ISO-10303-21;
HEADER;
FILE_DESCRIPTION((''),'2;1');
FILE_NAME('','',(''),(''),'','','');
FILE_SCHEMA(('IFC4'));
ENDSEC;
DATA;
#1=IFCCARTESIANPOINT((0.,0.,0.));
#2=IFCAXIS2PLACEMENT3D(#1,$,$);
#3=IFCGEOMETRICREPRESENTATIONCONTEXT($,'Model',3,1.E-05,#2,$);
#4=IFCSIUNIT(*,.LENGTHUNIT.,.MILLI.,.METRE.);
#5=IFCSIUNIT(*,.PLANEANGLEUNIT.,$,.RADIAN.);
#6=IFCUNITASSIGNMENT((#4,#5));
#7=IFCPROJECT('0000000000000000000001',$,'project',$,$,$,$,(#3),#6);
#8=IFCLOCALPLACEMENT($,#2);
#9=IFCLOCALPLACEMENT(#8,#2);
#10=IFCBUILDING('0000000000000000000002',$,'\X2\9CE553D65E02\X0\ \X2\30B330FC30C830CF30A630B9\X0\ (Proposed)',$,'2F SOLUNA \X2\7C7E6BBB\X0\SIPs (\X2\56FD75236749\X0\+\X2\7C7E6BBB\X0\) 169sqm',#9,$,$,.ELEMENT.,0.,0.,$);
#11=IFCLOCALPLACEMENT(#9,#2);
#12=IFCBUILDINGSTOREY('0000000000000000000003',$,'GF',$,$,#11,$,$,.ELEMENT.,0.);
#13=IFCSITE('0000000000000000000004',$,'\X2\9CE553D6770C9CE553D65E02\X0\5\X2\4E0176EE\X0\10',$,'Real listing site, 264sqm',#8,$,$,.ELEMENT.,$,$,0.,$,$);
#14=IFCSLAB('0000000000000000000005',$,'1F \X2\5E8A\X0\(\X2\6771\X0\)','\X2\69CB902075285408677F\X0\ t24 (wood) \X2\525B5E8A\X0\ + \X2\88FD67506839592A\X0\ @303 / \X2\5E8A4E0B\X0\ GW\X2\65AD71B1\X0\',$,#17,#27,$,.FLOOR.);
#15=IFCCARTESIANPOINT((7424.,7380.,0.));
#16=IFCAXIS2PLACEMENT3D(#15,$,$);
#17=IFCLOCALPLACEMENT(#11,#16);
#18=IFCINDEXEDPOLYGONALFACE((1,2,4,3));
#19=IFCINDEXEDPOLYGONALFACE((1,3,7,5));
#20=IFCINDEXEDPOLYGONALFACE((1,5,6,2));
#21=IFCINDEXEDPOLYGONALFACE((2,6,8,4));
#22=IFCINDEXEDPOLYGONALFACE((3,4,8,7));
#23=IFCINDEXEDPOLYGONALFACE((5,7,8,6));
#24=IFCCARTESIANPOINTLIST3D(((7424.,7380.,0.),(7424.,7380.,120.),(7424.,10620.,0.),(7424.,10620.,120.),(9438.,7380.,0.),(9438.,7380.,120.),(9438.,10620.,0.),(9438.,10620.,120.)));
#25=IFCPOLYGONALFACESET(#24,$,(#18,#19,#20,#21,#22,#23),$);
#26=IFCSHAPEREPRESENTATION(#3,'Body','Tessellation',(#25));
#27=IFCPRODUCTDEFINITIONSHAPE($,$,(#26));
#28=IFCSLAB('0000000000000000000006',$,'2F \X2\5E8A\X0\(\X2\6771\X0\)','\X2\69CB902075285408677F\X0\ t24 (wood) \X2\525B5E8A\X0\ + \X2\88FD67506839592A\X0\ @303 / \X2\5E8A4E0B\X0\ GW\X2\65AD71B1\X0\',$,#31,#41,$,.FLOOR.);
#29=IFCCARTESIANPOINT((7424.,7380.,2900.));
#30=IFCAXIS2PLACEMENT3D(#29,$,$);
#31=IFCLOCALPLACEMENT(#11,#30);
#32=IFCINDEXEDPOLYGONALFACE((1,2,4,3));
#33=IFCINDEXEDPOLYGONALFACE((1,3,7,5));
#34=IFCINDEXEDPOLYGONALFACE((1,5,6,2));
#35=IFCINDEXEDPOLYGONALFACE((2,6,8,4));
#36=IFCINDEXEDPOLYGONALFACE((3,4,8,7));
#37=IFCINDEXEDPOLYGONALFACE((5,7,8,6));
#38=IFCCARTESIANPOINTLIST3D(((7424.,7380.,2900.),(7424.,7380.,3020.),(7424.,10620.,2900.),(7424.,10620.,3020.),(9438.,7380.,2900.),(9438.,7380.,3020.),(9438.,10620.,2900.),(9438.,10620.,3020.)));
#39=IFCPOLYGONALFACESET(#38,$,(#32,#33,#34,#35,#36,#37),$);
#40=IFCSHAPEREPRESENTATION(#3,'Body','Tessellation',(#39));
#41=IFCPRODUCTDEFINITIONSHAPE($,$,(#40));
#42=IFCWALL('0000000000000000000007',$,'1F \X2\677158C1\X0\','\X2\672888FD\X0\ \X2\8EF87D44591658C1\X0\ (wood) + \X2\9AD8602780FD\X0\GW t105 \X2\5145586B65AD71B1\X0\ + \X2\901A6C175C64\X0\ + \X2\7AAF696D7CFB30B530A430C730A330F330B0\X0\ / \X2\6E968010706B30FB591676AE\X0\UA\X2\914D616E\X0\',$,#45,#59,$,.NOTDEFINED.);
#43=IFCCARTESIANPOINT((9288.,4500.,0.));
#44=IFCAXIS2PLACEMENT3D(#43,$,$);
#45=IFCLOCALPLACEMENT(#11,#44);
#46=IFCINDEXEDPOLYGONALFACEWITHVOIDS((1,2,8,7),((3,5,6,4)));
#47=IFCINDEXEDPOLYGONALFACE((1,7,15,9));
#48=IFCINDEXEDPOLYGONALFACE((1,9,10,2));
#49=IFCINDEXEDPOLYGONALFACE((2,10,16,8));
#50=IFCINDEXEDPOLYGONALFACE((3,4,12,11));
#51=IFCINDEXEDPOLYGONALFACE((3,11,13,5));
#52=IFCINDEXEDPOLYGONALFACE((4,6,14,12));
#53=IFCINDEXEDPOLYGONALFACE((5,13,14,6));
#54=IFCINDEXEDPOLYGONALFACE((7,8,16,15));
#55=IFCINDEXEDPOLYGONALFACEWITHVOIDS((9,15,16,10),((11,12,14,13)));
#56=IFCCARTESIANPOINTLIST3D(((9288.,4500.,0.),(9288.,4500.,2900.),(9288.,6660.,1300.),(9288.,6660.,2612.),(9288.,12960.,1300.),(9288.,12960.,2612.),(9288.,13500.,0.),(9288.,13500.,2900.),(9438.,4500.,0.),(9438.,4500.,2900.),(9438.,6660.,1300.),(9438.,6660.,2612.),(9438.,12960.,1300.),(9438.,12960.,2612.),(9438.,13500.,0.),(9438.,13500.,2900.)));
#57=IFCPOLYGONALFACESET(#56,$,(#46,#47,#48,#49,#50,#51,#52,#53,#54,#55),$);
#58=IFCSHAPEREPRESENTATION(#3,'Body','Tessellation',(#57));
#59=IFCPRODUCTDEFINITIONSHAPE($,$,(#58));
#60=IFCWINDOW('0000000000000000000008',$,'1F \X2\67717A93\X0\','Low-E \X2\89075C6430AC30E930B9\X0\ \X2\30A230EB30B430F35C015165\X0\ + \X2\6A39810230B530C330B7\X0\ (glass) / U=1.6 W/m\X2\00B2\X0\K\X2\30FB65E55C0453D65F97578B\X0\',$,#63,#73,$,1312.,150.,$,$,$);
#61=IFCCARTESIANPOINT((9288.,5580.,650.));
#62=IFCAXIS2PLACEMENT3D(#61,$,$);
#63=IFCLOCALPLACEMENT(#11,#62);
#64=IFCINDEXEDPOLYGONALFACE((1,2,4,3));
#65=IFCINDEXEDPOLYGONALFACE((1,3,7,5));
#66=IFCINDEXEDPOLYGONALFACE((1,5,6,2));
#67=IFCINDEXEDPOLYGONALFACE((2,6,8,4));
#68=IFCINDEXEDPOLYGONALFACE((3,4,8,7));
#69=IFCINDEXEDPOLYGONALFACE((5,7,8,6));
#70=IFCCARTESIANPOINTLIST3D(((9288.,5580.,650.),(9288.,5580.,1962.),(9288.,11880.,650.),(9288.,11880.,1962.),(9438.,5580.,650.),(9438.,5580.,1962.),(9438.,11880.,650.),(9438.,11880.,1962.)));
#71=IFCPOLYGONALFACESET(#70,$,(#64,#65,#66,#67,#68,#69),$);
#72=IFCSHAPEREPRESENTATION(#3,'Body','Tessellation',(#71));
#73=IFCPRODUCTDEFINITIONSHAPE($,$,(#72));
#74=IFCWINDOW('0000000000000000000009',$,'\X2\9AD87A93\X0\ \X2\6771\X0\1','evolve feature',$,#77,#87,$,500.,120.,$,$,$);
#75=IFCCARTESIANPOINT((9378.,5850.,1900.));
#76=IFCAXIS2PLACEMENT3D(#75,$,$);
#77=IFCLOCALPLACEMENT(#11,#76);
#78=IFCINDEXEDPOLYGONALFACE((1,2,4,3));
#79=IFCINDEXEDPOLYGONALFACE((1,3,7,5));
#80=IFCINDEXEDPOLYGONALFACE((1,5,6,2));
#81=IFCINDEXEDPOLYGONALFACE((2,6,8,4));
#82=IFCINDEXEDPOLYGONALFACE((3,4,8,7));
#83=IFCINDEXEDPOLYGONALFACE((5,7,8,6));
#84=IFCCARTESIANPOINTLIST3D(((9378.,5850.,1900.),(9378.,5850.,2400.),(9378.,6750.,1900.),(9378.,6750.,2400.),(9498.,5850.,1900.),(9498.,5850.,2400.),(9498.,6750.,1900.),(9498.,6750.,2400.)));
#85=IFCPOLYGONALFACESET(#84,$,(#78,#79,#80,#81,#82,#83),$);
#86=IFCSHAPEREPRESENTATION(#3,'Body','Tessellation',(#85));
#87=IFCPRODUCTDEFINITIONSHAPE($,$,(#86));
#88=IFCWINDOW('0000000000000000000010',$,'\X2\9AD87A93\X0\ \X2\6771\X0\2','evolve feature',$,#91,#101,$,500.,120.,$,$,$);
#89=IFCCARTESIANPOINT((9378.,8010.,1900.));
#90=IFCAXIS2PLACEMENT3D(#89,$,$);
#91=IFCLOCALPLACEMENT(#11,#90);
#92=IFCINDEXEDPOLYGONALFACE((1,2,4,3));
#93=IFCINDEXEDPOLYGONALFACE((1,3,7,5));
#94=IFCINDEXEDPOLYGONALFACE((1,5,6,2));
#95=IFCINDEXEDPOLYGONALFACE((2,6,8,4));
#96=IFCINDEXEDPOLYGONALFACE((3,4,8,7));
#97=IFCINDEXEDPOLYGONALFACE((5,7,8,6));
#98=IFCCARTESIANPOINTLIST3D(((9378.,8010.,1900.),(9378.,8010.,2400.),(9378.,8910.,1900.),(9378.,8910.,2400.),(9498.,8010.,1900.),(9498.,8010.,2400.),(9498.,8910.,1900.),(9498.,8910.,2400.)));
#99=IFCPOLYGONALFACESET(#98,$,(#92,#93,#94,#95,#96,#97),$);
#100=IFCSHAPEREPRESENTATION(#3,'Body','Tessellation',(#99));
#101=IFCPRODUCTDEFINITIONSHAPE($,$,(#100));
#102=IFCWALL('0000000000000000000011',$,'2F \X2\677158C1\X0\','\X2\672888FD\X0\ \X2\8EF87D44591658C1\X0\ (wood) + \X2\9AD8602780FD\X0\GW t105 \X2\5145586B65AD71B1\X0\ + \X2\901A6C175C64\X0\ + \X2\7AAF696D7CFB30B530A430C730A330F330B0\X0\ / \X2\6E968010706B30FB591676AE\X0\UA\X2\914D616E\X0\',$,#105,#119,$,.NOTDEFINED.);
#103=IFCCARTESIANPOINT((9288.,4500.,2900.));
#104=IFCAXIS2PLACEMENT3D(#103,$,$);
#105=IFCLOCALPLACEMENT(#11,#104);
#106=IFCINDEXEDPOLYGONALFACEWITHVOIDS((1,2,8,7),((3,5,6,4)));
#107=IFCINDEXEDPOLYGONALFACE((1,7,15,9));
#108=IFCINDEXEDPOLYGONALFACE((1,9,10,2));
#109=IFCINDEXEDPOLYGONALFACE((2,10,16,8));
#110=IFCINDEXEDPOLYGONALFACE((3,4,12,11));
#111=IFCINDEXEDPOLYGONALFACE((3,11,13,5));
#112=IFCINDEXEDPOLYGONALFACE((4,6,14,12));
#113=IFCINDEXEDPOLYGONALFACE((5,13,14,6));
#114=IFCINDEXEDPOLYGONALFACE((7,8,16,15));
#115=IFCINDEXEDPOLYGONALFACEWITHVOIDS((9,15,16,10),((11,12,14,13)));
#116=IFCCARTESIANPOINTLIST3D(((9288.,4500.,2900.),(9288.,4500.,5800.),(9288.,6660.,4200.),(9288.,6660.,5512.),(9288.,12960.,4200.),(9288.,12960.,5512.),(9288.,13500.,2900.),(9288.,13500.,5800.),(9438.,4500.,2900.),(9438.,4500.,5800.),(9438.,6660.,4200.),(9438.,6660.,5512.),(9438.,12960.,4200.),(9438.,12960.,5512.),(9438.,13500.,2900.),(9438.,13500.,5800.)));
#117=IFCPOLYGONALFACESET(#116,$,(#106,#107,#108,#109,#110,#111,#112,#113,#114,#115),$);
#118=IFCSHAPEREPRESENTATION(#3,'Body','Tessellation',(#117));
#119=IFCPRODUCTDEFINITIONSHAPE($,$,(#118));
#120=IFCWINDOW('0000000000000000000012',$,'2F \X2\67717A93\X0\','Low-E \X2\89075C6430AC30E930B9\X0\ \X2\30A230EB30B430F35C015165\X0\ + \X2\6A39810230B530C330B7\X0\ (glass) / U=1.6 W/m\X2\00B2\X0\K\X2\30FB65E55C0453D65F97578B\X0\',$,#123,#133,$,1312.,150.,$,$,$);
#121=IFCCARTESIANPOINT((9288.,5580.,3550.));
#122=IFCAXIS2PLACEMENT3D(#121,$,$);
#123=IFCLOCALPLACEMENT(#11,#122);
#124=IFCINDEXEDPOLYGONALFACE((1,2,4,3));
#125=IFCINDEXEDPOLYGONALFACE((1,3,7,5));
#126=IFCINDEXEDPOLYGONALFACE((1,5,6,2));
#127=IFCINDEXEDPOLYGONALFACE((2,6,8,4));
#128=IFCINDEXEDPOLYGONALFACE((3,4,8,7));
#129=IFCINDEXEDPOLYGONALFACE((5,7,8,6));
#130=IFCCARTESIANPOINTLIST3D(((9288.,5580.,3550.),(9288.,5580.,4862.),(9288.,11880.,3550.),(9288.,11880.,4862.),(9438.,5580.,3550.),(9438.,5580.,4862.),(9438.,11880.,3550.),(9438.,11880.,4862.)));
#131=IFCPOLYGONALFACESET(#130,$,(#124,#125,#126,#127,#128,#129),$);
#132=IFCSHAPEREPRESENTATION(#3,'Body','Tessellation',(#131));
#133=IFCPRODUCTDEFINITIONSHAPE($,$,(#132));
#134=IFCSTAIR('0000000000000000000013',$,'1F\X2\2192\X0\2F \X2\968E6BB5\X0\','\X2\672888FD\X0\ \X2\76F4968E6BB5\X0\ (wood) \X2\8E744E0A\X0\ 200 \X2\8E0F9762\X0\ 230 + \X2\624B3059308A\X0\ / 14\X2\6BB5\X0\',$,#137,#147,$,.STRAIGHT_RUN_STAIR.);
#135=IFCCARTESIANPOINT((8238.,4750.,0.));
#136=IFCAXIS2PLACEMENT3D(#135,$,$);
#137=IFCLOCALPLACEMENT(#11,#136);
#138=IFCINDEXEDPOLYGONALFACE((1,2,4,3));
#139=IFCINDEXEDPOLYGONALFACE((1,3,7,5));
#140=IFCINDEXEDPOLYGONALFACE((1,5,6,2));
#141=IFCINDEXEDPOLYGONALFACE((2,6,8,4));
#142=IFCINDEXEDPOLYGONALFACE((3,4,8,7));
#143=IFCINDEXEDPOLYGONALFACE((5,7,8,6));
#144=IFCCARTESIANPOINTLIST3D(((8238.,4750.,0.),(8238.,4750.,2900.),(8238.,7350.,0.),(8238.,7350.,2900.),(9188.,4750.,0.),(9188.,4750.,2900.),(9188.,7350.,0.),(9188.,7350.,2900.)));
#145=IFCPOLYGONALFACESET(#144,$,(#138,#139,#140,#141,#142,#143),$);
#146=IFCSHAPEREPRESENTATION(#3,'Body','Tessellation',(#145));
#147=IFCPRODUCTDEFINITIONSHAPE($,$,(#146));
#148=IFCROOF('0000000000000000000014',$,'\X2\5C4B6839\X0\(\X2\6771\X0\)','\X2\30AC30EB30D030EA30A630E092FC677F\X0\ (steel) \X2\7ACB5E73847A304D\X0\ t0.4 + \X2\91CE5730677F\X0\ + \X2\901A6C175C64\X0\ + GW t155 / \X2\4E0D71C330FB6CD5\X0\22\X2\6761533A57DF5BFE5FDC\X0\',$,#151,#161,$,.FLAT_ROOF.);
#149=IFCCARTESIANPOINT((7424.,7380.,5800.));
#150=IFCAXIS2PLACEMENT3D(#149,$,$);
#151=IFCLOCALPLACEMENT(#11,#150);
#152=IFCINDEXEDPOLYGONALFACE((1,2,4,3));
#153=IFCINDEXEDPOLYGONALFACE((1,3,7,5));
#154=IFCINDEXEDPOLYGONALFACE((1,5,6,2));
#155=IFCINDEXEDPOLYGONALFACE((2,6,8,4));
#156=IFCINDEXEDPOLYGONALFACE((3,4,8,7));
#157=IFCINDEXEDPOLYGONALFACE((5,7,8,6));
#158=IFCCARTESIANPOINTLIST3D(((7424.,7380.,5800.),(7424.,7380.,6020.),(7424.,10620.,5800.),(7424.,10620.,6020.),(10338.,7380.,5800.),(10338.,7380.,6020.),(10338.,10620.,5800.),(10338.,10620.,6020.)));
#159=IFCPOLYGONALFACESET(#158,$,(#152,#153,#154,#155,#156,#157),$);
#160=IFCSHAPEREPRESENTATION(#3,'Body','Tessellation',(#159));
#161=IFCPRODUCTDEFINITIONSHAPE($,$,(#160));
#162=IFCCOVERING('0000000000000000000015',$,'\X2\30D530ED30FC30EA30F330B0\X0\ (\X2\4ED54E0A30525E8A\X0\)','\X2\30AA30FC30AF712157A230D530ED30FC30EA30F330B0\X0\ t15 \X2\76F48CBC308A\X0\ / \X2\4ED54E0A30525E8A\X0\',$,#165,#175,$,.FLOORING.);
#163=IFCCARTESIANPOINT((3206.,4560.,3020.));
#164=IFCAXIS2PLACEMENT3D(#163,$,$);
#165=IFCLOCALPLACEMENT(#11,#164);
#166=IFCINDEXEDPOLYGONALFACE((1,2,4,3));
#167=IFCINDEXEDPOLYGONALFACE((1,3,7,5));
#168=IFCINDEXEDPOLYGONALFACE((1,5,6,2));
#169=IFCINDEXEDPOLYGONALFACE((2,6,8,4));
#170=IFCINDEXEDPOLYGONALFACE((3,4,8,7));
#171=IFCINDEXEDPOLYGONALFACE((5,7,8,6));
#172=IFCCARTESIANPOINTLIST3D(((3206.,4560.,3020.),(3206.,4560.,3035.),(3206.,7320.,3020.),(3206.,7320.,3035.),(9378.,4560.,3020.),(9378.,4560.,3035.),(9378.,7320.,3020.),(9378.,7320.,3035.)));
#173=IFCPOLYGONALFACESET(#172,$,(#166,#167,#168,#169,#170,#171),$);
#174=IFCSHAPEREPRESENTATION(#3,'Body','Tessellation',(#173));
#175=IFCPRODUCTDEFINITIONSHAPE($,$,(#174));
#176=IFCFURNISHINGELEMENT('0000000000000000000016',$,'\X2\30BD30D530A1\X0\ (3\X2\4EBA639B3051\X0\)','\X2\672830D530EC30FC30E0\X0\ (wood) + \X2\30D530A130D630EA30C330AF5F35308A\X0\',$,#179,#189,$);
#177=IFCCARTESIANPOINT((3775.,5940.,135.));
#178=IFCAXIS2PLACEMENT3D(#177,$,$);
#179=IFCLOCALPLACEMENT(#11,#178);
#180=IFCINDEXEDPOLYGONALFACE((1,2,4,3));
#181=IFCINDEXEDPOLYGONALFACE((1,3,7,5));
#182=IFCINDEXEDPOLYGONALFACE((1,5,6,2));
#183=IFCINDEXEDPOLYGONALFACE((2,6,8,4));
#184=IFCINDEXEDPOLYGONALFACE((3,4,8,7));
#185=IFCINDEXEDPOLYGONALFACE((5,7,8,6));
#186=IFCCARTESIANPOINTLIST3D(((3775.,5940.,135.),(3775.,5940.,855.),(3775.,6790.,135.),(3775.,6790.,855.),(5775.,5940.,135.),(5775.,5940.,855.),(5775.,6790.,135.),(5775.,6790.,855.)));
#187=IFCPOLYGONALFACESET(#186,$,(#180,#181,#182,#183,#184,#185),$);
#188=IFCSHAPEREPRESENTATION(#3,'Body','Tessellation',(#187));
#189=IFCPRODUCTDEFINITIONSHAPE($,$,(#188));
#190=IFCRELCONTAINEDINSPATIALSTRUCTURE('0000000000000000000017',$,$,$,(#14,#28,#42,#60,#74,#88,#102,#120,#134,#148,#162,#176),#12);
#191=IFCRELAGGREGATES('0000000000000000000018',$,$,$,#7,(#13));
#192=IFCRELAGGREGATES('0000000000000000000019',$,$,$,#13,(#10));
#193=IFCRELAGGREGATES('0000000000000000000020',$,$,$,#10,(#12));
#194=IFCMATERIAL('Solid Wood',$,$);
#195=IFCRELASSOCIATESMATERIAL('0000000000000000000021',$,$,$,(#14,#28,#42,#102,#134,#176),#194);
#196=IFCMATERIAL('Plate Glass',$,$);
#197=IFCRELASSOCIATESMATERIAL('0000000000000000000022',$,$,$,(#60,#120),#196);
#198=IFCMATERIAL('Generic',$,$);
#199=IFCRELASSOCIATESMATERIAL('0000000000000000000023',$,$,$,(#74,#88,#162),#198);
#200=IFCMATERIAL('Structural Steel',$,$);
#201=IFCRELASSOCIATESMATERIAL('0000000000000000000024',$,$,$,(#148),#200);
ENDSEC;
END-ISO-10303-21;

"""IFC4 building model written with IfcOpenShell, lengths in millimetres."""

from ifc_helpers import new_model, si_unit, frame, frame_2d, origin, place, context, project, spatial, rectangle, extrude, material, element, fill, save


model = new_model("IFC4")

# Units and contexts
model_context = context("Model", 3, precision=1e-05, world=origin())
ifc_project = project(units=[si_unit("LENGTHUNIT", "METRE", prefix="MILLI"), si_unit("PLANEANGLEUNIT", "RADIAN")], contexts=[model_context])

# Site, building, storey
site_placement = place(None, origin())
site = spatial("IfcSite", under=ifc_project, at=site_placement, Name="鳥取県鳥取市5丁目10", ObjectType="Real listing site, 264sqm", CompositionType="ELEMENT", RefElevation=0.0)
building_placement = place(site_placement, origin())
building = spatial("IfcBuilding", under=site, at=building_placement, Name="鳥取市 コートハウス (Proposed)", ObjectType="2F SOLUNA 籾殻SIPs (国産杉+籾殻) 169sqm", CompositionType="ELEMENT", ElevationOfRefHeight=0.0, ElevationOfTerrain=0.0)
storey_placement = place(building_placement, origin())
storey = spatial("IfcBuildingStorey", under=building, at=storey_placement, Name="GF", CompositionType="ELEMENT", Elevation=0.0)

# Slabs
ifc_material_1 = material(Name="Solid Wood")
slab_1_placement = place(storey_placement, frame((7424.0, 7380.0, 0.0)))
element("IfcSlab", 1, at=slab_1_placement, inside=storey, material=ifc_material_1, Name="1F 床(東)", Description="構造用合板 t24 (wood) 剛床 + 製材根太 @303 / 床下 GW断熱", PredefinedType="FLOOR", context=model_context, shape_type="SweptSolid", body=[
    extrude(rectangle(XDim=2014.0, YDim=3240.0, at=frame_2d((1007.0, 1620.0))), frame((7424.0, 7380.0, 0.0)), (0.0, 0.0, 1.0), 120.0),
])
slab_2_placement = place(storey_placement, frame((7424.0, 7380.0, 2900.0)))
element("IfcSlab", 2, at=slab_2_placement, inside=storey, material=ifc_material_1, Name="2F 床(東)", Description="構造用合板 t24 (wood) 剛床 + 製材根太 @303 / 床下 GW断熱", PredefinedType="FLOOR", context=model_context, shape_type="SweptSolid", body=[
    extrude(rectangle(XDim=2014.0, YDim=3240.0, at=frame_2d((1007.0, 1620.0))), frame((7424.0, 7380.0, 2900.0)), (0.0, 0.0, 1.0), 120.0),
])

# Wall, openings, windows
wall_1_placement = place(storey_placement, frame((9288.0, 4500.0, 0.0)))
wall_1 = element("IfcWall", 3, at=wall_1_placement, inside=storey, material=ifc_material_1, Name="1F 東壁", Description="木製 軸組外壁 (wood) + 高性能GW t105 充填断熱 + 通気層 + 窯業系サイディング / 準耐火・外皮UA配慮", PredefinedType="NOTDEFINED", context=model_context, shape_type="SweptSolid", body=[
    extrude(rectangle(XDim=150.0, YDim=9000.0, at=frame_2d((75.0, 4500.0))), frame((9288.0, 4500.0, 0.0)), (0.0, 0.0, 1.0), 2900.0),
])
opening_1_placement = place(storey_placement, frame((9288.0, 5580.0, 650.0)))
opening_1 = element("IfcOpeningElement", 4, at=opening_1_placement, cuts=wall_1, PredefinedType="NOTDEFINED", context=model_context, shape_type="SweptSolid", body=[
    extrude(rectangle(XDim=150.0, YDim=6300.0, at=frame_2d((75.0, 3150.0))), frame((9288.0, 5580.0, 650.0)), (0.0, 0.0, 1.0), 1312.0),
])
opening_2_placement = place(storey_placement, frame((9378.0, 5850.0, 1900.0)))
opening_2 = element("IfcOpeningElement", 5, at=opening_2_placement, cuts=wall_1, PredefinedType="NOTDEFINED", context=model_context, shape_type="SweptSolid", body=[
    extrude(rectangle(XDim=120.0, YDim=900.0, at=frame_2d((60.0, 450.0))), frame((9378.0, 5850.0, 1900.0)), (0.0, 0.0, 1.0), 500.0),
])
opening_3_placement = place(storey_placement, frame((9378.0, 8010.0, 1900.0)))
opening_3 = element("IfcOpeningElement", 6, at=opening_3_placement, cuts=wall_1, PredefinedType="NOTDEFINED", context=model_context, shape_type="SweptSolid", body=[
    extrude(rectangle(XDim=120.0, YDim=900.0, at=frame_2d((60.0, 450.0))), frame((9378.0, 8010.0, 1900.0)), (0.0, 0.0, 1.0), 500.0),
])
ifc_material_2 = material(Name="Plate Glass")
window_1_placement = place(storey_placement, frame((9288.0, 5580.0, 650.0)))
window_1 = element("IfcWindow", 7, at=window_1_placement, inside=storey, material=ifc_material_2, Name="1F 東窓", Description="Low-E 複層ガラス アルゴン封入 + 樹脂サッシ (glass) / U=1.6 W/m²K・日射取得型", OverallHeight=1312.0, OverallWidth=150.0, context=model_context, shape_type="SweptSolid", body=[
    extrude(rectangle(XDim=150.0, YDim=6300.0, at=frame_2d((75.0, 3150.0))), frame((9288.0, 5580.0, 650.0)), (0.0, 0.0, 1.0), 1312.0),
])
fill(opening_1, window_1)
ifc_material_3 = material(Name="Generic")
window_2_placement = place(storey_placement, frame((9378.0, 5850.0, 1900.0)))
window_2 = element("IfcWindow", 8, at=window_2_placement, inside=storey, material=ifc_material_3, Name="高窓 東1", Description="evolve feature", OverallHeight=500.0, OverallWidth=120.0, context=model_context, shape_type="SweptSolid", body=[
    extrude(rectangle(XDim=120.0, YDim=900.0, at=frame_2d((60.0, 450.0))), frame((9378.0, 5850.0, 1900.0)), (0.0, 0.0, 1.0), 500.0),
])
fill(opening_2, window_2)
window_3_placement = place(storey_placement, frame((9378.0, 8010.0, 1900.0)))
window_3 = element("IfcWindow", 9, at=window_3_placement, inside=storey, material=ifc_material_3, Name="高窓 東2", Description="evolve feature", OverallHeight=500.0, OverallWidth=120.0, context=model_context, shape_type="SweptSolid", body=[
    extrude(rectangle(XDim=120.0, YDim=900.0, at=frame_2d((60.0, 450.0))), frame((9378.0, 8010.0, 1900.0)), (0.0, 0.0, 1.0), 500.0),
])
fill(opening_3, window_3)

# Wall, opening, window
wall_2_placement = place(storey_placement, frame((9288.0, 4500.0, 2900.0)))
wall_2 = element("IfcWall", 10, at=wall_2_placement, inside=storey, material=ifc_material_1, Name="2F 東壁", Description="木製 軸組外壁 (wood) + 高性能GW t105 充填断熱 + 通気層 + 窯業系サイディング / 準耐火・外皮UA配慮", PredefinedType="NOTDEFINED", context=model_context, shape_type="SweptSolid", body=[
    extrude(rectangle(XDim=150.0, YDim=9000.0, at=frame_2d((75.0, 4500.0))), frame((9288.0, 4500.0, 2900.0)), (0.0, 0.0, 1.0), 2900.0),
])
opening_4_placement = place(storey_placement, frame((9288.0, 5580.0, 3550.0)))
opening_4 = element("IfcOpeningElement", 11, at=opening_4_placement, cuts=wall_2, PredefinedType="NOTDEFINED", context=model_context, shape_type="SweptSolid", body=[
    extrude(rectangle(XDim=150.0, YDim=6300.0, at=frame_2d((75.0, 3150.0))), frame((9288.0, 5580.0, 3550.0)), (0.0, 0.0, 1.0), 1312.0),
])
window_4_placement = place(storey_placement, frame((9288.0, 5580.0, 3550.0)))
window_4 = element("IfcWindow", 12, at=window_4_placement, inside=storey, material=ifc_material_2, Name="2F 東窓", Description="Low-E 複層ガラス アルゴン封入 + 樹脂サッシ (glass) / U=1.6 W/m²K・日射取得型", OverallHeight=1312.0, OverallWidth=150.0, context=model_context, shape_type="SweptSolid", body=[
    extrude(rectangle(XDim=150.0, YDim=6300.0, at=frame_2d((75.0, 3150.0))), frame((9288.0, 5580.0, 3550.0)), (0.0, 0.0, 1.0), 1312.0),
])
fill(opening_4, window_4)

# Stair
stair_placement = place(storey_placement, frame((8238.0, 4750.0, 0.0)))
element("IfcStair", 13, at=stair_placement, inside=storey, material=ifc_material_1, Name="1F→2F 階段", Description="木製 直階段 (wood) 蹴上 200 踏面 230 + 手すり / 14段", PredefinedType="STRAIGHT_RUN_STAIR", context=model_context, shape_type="SweptSolid", body=[
    extrude(rectangle(XDim=950.0, YDim=2600.0, at=frame_2d((475.0, 1300.0))), frame((8238.0, 4750.0, 0.0)), (0.0, 0.0, 1.0), 2900.0),
])

# Roof
ifc_material_4 = material(Name="Structural Steel")
roof_placement = place(storey_placement, frame((7424.0, 7380.0, 5800.0)))
element("IfcRoof", 14, at=roof_placement, inside=storey, material=ifc_material_4, Name="屋根(東)", Description="ガルバリウム鋼板 (steel) 立平葺き t0.4 + 野地板 + 通気層 + GW t155 / 不燃・法22条区域対応", PredefinedType="FLAT_ROOF", context=model_context, shape_type="SweptSolid", body=[
    extrude(rectangle(XDim=2914.0, YDim=3240.0, at=frame_2d((1457.0, 1620.0))), frame((7424.0, 7380.0, 5800.0)), (0.0, 0.0, 1.0), 220.0),
])

# Covering
covering_placement = place(storey_placement, frame((3206.0, 4560.0, 3020.0)))
element("IfcCovering", 15, at=covering_placement, inside=storey, material=ifc_material_3, Name="フローリング (仕上げ床)", Description="オーク無垢フローリング t15 直貼り / 仕上げ床", PredefinedType="FLOORING", context=model_context, shape_type="SweptSolid", body=[
    extrude(rectangle(XDim=6172.0, YDim=2760.0, at=frame_2d((3086.0, 1380.0))), frame((3206.0, 4560.0, 3020.0)), (0.0, 0.0, 1.0), 15.0),
])

# Furnishing element
furnishing_1_placement = place(storey_placement, frame((3775.0, 5940.0, 135.0)))
element("IfcFurnishingElement", 16, at=furnishing_1_placement, inside=storey, material=ifc_material_1, Name="ソファ (3人掛け)", Description="木フレーム (wood) + ファブリック張り", context=model_context, shape_type="SweptSolid", body=[
    extrude(rectangle(XDim=2000.0, YDim=850.0, at=frame_2d((1000.0, 425.0))), frame((3775.0, 5940.0, 135.0)), (0.0, 0.0, 1.0), 720.0),
])

save(model, "model.ifc")
